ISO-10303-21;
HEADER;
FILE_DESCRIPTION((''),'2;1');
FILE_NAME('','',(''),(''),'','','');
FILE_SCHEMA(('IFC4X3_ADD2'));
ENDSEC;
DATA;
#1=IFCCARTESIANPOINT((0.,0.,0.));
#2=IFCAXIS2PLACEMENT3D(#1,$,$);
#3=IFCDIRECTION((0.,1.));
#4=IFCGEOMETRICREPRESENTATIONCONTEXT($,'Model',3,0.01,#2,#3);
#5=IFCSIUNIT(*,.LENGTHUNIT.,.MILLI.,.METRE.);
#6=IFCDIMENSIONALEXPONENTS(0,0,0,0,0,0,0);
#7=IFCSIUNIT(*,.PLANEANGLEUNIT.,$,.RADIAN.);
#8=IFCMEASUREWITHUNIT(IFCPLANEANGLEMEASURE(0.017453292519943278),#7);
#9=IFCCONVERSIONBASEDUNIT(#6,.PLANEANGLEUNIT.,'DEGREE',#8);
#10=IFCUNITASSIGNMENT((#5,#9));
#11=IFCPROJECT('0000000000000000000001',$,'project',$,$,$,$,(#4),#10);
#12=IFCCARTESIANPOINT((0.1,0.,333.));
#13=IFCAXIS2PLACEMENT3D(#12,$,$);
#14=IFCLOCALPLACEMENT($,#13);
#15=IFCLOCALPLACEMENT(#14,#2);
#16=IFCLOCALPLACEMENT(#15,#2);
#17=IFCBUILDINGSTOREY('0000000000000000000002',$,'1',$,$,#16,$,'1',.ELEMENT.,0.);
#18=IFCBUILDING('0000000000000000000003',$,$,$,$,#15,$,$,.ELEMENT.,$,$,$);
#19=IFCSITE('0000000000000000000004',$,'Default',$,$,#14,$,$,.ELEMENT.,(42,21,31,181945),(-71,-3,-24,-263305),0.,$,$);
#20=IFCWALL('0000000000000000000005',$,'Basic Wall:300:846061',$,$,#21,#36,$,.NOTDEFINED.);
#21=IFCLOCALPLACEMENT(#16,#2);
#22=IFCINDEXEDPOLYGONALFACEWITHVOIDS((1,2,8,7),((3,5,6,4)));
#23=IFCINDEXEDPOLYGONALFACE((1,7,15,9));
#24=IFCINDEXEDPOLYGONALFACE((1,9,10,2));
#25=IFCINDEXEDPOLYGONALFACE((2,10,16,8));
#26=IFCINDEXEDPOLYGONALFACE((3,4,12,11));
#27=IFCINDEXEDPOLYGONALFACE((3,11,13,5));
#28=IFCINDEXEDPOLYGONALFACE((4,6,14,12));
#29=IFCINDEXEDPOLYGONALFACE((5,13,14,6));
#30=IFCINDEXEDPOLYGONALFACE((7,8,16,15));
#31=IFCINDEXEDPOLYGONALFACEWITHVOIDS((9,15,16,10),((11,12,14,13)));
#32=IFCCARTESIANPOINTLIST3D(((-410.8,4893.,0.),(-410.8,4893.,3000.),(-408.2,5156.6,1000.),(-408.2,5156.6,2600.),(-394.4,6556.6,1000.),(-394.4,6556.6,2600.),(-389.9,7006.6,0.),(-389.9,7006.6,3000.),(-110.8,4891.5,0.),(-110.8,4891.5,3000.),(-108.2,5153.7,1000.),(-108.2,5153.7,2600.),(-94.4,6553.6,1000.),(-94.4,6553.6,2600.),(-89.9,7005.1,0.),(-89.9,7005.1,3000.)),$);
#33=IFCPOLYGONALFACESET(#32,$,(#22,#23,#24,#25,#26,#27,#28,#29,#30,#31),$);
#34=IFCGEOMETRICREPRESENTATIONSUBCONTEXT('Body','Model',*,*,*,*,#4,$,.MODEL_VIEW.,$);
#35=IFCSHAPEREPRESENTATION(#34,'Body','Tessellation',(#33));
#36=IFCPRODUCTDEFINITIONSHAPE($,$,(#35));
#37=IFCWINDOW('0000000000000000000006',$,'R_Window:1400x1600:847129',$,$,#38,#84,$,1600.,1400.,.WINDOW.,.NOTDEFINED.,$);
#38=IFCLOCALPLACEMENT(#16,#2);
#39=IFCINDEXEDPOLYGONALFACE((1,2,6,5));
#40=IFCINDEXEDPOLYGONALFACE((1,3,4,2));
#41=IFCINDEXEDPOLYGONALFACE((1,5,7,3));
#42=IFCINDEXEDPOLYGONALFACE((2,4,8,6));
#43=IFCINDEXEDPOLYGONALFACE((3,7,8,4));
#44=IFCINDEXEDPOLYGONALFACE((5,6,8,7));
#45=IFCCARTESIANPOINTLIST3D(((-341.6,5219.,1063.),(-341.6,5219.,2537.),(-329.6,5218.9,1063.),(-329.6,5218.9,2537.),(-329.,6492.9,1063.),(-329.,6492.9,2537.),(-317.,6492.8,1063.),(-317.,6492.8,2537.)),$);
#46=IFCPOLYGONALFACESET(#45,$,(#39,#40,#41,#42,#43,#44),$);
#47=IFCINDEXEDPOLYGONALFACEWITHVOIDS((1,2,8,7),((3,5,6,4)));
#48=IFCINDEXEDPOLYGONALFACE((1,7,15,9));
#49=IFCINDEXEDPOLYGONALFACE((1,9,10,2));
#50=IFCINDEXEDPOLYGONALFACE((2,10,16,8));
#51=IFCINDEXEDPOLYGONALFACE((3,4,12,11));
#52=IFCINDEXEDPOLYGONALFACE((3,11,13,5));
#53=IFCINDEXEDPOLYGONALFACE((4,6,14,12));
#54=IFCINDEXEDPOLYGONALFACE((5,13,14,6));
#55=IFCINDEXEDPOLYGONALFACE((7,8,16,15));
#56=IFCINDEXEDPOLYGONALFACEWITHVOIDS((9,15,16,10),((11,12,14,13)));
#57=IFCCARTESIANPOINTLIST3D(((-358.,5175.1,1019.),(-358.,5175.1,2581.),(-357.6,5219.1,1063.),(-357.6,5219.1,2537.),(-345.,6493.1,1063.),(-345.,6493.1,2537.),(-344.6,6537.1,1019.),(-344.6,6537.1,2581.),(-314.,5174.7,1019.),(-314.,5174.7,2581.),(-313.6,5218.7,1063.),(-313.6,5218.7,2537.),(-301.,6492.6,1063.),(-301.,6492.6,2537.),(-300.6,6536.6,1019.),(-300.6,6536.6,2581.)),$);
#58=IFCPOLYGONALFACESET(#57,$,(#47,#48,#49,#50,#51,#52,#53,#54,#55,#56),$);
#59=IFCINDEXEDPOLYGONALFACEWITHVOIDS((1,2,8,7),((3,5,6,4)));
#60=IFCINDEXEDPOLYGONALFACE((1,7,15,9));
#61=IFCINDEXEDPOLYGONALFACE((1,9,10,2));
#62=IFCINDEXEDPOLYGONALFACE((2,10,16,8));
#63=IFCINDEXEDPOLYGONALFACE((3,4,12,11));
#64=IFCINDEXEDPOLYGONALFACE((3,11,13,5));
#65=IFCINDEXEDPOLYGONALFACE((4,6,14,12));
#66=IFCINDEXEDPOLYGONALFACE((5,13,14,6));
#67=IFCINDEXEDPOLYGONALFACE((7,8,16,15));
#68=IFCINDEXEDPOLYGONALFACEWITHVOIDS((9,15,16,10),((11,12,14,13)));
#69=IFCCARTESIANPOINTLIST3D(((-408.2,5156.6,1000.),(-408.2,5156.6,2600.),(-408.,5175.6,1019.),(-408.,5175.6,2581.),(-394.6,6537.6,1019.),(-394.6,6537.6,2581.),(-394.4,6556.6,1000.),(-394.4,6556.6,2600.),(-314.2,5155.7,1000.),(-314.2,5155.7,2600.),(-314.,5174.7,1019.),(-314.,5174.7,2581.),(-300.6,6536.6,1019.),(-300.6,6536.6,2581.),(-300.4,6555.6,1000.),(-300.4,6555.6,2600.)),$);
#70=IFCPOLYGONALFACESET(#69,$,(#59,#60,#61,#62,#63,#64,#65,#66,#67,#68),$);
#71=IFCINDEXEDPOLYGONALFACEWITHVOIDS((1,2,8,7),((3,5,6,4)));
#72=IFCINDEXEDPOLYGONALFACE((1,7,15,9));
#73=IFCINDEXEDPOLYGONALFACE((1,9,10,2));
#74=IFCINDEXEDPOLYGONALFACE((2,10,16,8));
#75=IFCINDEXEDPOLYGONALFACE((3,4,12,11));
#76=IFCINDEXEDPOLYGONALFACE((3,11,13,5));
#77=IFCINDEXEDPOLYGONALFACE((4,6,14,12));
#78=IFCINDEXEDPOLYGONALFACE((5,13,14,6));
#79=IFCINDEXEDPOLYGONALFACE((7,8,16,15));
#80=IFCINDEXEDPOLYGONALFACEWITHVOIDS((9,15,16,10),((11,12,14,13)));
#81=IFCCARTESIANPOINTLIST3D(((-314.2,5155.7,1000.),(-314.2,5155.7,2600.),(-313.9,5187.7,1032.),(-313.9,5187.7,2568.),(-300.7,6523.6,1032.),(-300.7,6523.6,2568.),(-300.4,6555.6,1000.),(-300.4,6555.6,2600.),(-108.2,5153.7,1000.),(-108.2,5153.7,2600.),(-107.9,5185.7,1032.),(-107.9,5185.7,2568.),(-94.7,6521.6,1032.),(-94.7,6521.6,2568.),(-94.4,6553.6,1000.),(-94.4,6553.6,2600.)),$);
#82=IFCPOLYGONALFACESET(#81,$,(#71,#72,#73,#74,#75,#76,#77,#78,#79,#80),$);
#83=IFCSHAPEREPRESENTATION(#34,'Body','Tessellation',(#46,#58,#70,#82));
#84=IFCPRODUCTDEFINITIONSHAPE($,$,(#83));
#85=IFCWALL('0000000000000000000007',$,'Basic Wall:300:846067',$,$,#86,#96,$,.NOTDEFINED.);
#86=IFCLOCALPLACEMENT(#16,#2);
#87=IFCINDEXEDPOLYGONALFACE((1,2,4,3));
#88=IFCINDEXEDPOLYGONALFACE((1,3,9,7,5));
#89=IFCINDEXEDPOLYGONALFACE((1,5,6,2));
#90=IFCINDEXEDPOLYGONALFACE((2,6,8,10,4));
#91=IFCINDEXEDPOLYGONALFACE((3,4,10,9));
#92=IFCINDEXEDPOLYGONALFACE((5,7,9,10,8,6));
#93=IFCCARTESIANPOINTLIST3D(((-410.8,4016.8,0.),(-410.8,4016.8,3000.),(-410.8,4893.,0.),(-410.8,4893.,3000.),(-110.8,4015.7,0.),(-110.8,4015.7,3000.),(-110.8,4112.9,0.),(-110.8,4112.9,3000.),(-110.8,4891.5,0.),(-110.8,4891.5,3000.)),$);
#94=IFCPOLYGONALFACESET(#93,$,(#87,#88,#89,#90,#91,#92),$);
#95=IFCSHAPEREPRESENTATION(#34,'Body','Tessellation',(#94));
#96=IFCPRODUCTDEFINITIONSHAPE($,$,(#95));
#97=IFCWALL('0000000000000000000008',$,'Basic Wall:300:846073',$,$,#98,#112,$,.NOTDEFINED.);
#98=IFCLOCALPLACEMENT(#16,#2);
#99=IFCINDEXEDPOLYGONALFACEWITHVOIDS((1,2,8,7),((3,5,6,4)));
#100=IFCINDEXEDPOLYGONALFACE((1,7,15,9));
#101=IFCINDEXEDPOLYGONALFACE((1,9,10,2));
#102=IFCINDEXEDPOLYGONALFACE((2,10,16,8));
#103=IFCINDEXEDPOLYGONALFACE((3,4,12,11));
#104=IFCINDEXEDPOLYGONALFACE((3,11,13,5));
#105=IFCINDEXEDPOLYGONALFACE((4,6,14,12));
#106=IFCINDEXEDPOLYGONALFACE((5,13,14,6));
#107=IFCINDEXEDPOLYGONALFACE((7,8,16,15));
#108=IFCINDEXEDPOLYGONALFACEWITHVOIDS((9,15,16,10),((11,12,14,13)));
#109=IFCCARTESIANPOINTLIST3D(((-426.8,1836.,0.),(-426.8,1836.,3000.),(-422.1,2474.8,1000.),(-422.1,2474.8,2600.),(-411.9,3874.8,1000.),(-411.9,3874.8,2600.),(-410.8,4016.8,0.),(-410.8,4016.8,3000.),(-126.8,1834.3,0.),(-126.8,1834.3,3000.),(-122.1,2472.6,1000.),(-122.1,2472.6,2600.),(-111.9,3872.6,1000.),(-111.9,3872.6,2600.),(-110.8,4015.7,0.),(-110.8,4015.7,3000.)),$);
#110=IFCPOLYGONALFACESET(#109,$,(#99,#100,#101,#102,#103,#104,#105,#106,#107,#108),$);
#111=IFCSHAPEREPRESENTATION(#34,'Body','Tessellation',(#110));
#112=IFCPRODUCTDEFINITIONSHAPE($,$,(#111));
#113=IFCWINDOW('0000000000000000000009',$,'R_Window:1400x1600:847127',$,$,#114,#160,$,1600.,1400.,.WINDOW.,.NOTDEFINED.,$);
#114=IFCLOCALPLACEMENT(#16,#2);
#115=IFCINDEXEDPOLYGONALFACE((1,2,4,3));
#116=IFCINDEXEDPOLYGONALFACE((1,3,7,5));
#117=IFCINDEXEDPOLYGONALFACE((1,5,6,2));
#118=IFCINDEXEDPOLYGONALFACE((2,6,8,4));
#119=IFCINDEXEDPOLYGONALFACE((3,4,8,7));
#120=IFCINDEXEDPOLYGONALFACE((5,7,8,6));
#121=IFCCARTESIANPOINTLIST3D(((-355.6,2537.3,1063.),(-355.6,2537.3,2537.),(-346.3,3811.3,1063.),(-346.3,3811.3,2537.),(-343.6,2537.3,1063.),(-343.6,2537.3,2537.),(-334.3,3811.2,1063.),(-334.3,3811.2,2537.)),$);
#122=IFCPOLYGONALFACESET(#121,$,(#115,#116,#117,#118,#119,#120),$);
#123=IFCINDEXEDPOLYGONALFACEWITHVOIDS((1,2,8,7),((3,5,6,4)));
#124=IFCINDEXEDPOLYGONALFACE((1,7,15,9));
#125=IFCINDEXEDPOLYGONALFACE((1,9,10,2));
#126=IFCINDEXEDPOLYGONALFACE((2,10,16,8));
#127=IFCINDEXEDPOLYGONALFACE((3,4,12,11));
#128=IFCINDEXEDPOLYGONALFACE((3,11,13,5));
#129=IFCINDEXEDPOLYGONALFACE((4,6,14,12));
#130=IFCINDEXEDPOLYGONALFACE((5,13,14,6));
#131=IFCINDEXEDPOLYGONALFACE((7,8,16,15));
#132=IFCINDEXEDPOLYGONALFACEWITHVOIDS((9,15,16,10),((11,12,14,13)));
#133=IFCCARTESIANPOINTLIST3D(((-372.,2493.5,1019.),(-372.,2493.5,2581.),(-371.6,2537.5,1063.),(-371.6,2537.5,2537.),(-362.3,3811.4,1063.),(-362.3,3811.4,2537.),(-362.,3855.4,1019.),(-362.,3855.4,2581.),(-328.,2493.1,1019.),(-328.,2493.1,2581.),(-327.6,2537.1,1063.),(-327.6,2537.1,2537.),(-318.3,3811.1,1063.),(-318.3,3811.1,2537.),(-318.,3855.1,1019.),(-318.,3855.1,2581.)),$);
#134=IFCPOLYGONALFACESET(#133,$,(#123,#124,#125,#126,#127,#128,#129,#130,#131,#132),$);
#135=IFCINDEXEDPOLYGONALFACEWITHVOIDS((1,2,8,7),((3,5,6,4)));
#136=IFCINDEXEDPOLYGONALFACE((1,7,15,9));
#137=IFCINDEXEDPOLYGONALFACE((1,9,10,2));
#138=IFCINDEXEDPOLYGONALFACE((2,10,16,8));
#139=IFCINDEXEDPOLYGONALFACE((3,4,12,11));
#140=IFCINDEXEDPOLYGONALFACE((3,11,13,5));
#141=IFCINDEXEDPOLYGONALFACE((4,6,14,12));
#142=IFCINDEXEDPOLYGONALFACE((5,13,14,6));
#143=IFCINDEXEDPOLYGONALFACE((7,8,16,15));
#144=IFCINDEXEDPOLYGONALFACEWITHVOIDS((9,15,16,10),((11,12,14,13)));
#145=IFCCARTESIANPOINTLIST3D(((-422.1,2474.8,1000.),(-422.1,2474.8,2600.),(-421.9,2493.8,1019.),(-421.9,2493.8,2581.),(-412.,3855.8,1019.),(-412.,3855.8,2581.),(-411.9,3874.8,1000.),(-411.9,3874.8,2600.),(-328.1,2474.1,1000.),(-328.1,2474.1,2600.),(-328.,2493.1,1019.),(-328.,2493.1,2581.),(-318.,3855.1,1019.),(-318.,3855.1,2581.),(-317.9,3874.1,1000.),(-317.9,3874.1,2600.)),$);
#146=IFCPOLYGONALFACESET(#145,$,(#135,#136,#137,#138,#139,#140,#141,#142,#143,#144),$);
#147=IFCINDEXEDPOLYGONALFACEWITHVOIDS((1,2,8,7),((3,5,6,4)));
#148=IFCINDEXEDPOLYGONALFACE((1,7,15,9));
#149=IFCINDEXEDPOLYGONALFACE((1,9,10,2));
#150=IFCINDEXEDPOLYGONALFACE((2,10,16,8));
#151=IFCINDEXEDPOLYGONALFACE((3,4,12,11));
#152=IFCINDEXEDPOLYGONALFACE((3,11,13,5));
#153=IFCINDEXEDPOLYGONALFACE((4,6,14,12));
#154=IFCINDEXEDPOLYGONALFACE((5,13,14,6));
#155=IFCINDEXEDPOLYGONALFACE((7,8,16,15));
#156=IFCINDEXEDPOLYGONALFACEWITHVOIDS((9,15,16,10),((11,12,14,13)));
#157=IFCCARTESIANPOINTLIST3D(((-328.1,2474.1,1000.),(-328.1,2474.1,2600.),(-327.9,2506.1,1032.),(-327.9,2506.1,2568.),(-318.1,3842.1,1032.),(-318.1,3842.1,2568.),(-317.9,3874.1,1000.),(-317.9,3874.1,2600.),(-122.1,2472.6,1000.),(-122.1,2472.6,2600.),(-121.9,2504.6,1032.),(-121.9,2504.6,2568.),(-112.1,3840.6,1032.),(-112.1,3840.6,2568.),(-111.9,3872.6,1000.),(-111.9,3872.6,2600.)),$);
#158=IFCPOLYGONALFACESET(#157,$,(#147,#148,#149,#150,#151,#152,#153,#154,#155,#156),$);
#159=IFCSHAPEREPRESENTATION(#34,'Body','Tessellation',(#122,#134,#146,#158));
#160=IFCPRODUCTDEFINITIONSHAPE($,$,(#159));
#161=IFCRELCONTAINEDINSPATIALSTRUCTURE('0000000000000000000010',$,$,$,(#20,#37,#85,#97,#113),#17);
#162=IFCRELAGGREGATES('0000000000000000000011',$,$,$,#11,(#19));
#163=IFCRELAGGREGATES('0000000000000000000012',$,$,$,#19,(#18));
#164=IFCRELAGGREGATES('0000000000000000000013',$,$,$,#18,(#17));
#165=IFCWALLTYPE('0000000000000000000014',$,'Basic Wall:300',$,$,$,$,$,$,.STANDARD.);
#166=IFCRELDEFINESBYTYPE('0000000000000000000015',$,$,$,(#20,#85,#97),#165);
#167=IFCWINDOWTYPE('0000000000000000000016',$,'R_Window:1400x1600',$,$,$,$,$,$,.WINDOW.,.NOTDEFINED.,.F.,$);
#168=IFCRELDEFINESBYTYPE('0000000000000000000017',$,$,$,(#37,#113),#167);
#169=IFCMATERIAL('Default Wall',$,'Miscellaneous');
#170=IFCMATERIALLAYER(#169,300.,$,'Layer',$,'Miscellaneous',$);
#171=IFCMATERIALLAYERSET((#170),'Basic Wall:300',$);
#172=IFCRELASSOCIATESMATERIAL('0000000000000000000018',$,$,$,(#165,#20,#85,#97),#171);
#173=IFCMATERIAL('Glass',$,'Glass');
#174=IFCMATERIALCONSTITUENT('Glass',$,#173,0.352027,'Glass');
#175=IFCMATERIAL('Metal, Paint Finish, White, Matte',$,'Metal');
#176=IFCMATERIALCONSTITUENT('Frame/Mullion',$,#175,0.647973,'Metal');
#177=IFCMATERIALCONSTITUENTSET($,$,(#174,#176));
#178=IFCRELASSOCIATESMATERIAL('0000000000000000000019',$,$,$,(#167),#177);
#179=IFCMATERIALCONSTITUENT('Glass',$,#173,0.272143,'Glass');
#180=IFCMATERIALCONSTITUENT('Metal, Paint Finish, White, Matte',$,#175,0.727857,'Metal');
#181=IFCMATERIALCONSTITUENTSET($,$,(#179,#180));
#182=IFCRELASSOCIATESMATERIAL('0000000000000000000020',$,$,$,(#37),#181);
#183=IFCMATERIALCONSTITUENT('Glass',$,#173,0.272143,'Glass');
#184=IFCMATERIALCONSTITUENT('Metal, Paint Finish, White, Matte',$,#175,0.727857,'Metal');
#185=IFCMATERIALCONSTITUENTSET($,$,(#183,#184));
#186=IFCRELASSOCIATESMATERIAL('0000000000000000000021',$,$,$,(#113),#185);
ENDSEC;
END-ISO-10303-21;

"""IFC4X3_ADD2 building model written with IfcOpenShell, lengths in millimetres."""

from ifc_helpers import new_model, entity, si_unit, converted_unit, direction, frame, frame_2d, origin, place, context, subcontext, project, spatial, polyline, rectangle, outline, extrude, source, transform, mapped, material, layer, layer_set, constituent, constituent_set, type_object, type_shapes, element, fill, save


model = new_model("IFC4X3_ADD2")

# Units and contexts
model_context = context("Model", 3, precision=0.01, world=origin(), true_north=direction((0.0, 1.0)))
body_context = subcontext(model_context, "Body", "Model", "MODEL_VIEW")
ifc_project = project(units=[si_unit("LENGTHUNIT", "METRE", prefix="MILLI"), converted_unit("PLANEANGLEUNIT", "DEGREE", entity("IfcPlaneAngleMeasure", 0.017453292519943278), si_unit("PLANEANGLEUNIT", "RADIAN"), dimensions=[0, 0, 0, 0, 0, 0, 0])], contexts=[model_context])

# Site, building, storey
site_placement = place(None, frame((0.1, 0.0, 333.0)))
site = spatial("IfcSite", under=ifc_project, at=site_placement, Name="Default", CompositionType="ELEMENT", RefLatitude=(42, 21, 31, 181945), RefLongitude=(-71, -3, -24, -263305), RefElevation=0.0)
building_placement = place(site_placement, origin())
building = spatial("IfcBuilding", under=site, at=building_placement, CompositionType="ELEMENT")
storey_placement = place(building_placement, origin())
storey = spatial("IfcBuildingStorey", under=building, at=storey_placement, Name="1", LongName="1", CompositionType="ELEMENT", Elevation=0.0)

# Wall, opening, window
ifc_material_1 = material(Name="Default Wall", Category="Miscellaneous")
ifc_layer_1 = layer(ifc_material_1, 300.0, Name="Layer", Category="Miscellaneous")
ifc_layer_set_1 = layer_set([ifc_layer_1], Name="Basic Wall:300")
wall_type_1 = type_object("IfcWallType", Name="Basic Wall:300", PredefinedType="STANDARD", material=ifc_layer_set_1)
wall_1_placement = place(storey_placement, frame((-260.8, 4891.5, 0.0), z_axis=(0.0, 0.0, 1.0), x_axis=(0.009898, 0.999951, 0.0)))
wall_1 = element("IfcWall", 1, at=wall_1_placement, inside=storey, type_object=wall_type_1, material=ifc_layer_set_1, Name="Basic Wall:300:846061", PredefinedType="NOTDEFINED", context=body_context, shape_type="SweptSolid", body=[
    extrude(outline(polyline([(2115.2, -150.0), (2113.7, 150.0), (0.0, 150.0), (1.5, -150.0), (2115.2, -150.0)])), origin(), (0.0, 0.0, 1.0), 3000.0),
])
opening_1_placement = place(wall_1_placement, frame((263.7, -150.0, 1000.0)))
opening_1 = element("IfcOpeningElement", 2, at=opening_1_placement, cuts=wall_1, PredefinedType="OPENING", context=body_context, shape_type="SweptSolid", body=[
    extrude(rectangle(XDim=1600.0, YDim=1400.0, at=frame_2d((800.0, 700.0), x_axis=(1.0, 0.0))), frame((0.0, 0.0, 0.0), z_axis=(0.0, 1.0, 0.0), x_axis=(0.0, 0.0, 1.0)), (0.0, 0.0, 1.0), 300.0),
])
ifc_material_2 = material(Name="Glass", Category="Glass")
ifc_constituent_1 = constituent(ifc_material_2, Name="Glass", Category="Glass", fraction=0.272143)
ifc_material_3 = material(Name="Metal, Paint Finish, White, Matte", Category="Metal")
ifc_constituent_2 = constituent(ifc_material_3, Name="Metal, Paint Finish, White, Matte", Category="Metal", fraction=0.727857)
ifc_constituent_set_1 = constituent_set(constituents=[ifc_constituent_1, ifc_constituent_2])
ifc_constituent_3 = constituent(ifc_material_2, Name="Glass", Category="Glass", fraction=0.352027)
ifc_constituent_4 = constituent(ifc_material_3, Name="Frame/Mullion", Category="Metal", fraction=0.647973)
ifc_constituent_set_2 = constituent_set(constituents=[ifc_constituent_3, ifc_constituent_4])
window_type = type_object("IfcWindowType", Name="R_Window:1400x1600", ParameterTakesPrecedence=False, PartitioningType="NOTDEFINED", PredefinedType="WINDOW", material=ifc_constituent_set_2)
shared_shape_1 = source(origin(), body_context, "Body", "SweptSolid", [
    extrude(rectangle(XDim=12.0, YDim=1274.0, at=frame_2d((0.0, 0.0), x_axis=(1.0, 0.0))), frame((700.0, 228.0, 63.0), z_axis=(0.0, 0.0, 1.0), x_axis=(0.0, -1.0, 0.0)), (0.0, 0.0, 1.0), 1474.0),
    extrude(outline(polyline([(-681.0, -781.0), (681.0, -781.0), (681.0, 781.0), (-681.0, 781.0), (-681.0, -781.0)]), holes=[polyline([(-637.0, -737.0), (-637.0, 737.0), (637.0, 737.0), (637.0, -737.0), (-637.0, -737.0)])]), frame((700.0, 206.0, 800.0), z_axis=(0.0, 1.0, 0.0), x_axis=(1.0, 0.0, 0.0)), (0.0, 0.0, 1.0), 44.0),
    extrude(outline(polyline([(-700.0, -800.0), (700.0, -800.0), (700.0, 800.0), (-700.0, 800.0), (-700.0, -800.0)]), holes=[polyline([(-681.0, -781.0), (-681.0, 781.0), (681.0, 781.0), (681.0, -781.0), (-681.0, -781.0)])]), frame((700.0, 206.0, 800.0), z_axis=(0.0, 1.0, 0.0), x_axis=(1.0, 0.0, 0.0)), (0.0, 0.0, 1.0), 94.0),
    extrude(outline(polyline([(-700.0, -800.0), (700.0, -800.0), (700.0, 800.0), (-700.0, 800.0), (-700.0, -800.0)]), holes=[polyline([(-668.0, -768.0), (-668.0, 768.0), (668.0, 768.0), (668.0, -768.0), (-668.0, -768.0)])]), frame((700.0, 0.0, 800.0), z_axis=(0.0, 1.0, 0.0), x_axis=(1.0, 0.0, 0.0)), (0.0, 0.0, 1.0), 206.0),
])
type_shapes(window_type, [shared_shape_1])
window_1_placement = place(opening_1_placement, origin())
window_1 = element("IfcWindow", 3, at=window_1_placement, inside=storey, type_object=window_type, material=ifc_constituent_set_1, Name="R_Window:1400x1600:847129", OverallHeight=1600.0, OverallWidth=1400.0, PartitioningType="NOTDEFINED", PredefinedType="WINDOW", context=body_context, shape_type="MappedRepresentation", body=[
    mapped(shared_shape_1, transform((0.0, 0.0, 0.0), scale=1.0)),
])
fill(opening_1, window_1)

# Wall
wall_2_placement = place(storey_placement, frame((-260.8, 4015.7, 0.0), z_axis=(0.0, 0.0, 1.0), x_axis=(0.0, 1.0, 0.0)))
element("IfcWall", 4, at=wall_2_placement, inside=storey, type_object=wall_type_1, material=ifc_layer_set_1, Name="Basic Wall:300:846067", PredefinedType="NOTDEFINED", context=body_context, shape_type="SweptSolid", body=[
    extrude(outline(polyline([(875.8, -150.0), (877.3, 150.0), (1.1, 150.0), (0.0, -150.0), (97.1, -150.0), (875.8, -150.0)])), origin(), (0.0, 0.0, 1.0), 3000.0),
])

# Wall, opening, window
wall_3_placement = place(storey_placement, frame((-276.8, 1834.9, 0.0), z_axis=(0.0, 0.0, 1.0), x_axis=(0.007299, 0.999973, 0.0)))
wall_3 = element("IfcWall", 5, at=wall_3_placement, inside=storey, type_object=wall_type_1, material=ifc_layer_set_1, Name="Basic Wall:300:846073", PredefinedType="NOTDEFINED", context=body_context, shape_type="SweptSolid", body=[
    extrude(outline(polyline([(2182.0, -150.0), (2180.9, 150.0), (0.0, 150.0), (0.5, -150.0), (2179.1, -150.0), (2182.0, -150.0)])), origin(), (0.0, 0.0, 1.0), 3000.0),
])
opening_2_placement = place(wall_3_placement, frame((638.9, -150.0, 1000.0)))
opening_2 = element("IfcOpeningElement", 6, at=opening_2_placement, cuts=wall_3, PredefinedType="OPENING", context=body_context, shape_type="SweptSolid", body=[
    extrude(rectangle(XDim=1600.0, YDim=1400.0, at=frame_2d((800.0, 700.0), x_axis=(1.0, 0.0))), frame((0.0, 0.0, 0.0), z_axis=(0.0, 1.0, 0.0), x_axis=(0.0, 0.0, 1.0)), (0.0, 0.0, 1.0), 300.0),
])
ifc_constituent_5 = constituent(ifc_material_2, Name="Glass", Category="Glass", fraction=0.272143)
ifc_constituent_6 = constituent(ifc_material_3, Name="Metal, Paint Finish, White, Matte", Category="Metal", fraction=0.727857)
ifc_constituent_set_3 = constituent_set(constituents=[ifc_constituent_5, ifc_constituent_6])
window_2_placement = place(opening_2_placement, origin())
window_2 = element("IfcWindow", 7, at=window_2_placement, inside=storey, type_object=window_type, material=ifc_constituent_set_3, Name="R_Window:1400x1600:847127", OverallHeight=1600.0, OverallWidth=1400.0, PartitioningType="NOTDEFINED", PredefinedType="WINDOW", context=body_context, shape_type="MappedRepresentation", body=[
    mapped(shared_shape_1, transform((0.0, 0.0, 0.0), scale=1.0)),
])
fill(opening_2, window_2)

save(model, "model.ifc")
